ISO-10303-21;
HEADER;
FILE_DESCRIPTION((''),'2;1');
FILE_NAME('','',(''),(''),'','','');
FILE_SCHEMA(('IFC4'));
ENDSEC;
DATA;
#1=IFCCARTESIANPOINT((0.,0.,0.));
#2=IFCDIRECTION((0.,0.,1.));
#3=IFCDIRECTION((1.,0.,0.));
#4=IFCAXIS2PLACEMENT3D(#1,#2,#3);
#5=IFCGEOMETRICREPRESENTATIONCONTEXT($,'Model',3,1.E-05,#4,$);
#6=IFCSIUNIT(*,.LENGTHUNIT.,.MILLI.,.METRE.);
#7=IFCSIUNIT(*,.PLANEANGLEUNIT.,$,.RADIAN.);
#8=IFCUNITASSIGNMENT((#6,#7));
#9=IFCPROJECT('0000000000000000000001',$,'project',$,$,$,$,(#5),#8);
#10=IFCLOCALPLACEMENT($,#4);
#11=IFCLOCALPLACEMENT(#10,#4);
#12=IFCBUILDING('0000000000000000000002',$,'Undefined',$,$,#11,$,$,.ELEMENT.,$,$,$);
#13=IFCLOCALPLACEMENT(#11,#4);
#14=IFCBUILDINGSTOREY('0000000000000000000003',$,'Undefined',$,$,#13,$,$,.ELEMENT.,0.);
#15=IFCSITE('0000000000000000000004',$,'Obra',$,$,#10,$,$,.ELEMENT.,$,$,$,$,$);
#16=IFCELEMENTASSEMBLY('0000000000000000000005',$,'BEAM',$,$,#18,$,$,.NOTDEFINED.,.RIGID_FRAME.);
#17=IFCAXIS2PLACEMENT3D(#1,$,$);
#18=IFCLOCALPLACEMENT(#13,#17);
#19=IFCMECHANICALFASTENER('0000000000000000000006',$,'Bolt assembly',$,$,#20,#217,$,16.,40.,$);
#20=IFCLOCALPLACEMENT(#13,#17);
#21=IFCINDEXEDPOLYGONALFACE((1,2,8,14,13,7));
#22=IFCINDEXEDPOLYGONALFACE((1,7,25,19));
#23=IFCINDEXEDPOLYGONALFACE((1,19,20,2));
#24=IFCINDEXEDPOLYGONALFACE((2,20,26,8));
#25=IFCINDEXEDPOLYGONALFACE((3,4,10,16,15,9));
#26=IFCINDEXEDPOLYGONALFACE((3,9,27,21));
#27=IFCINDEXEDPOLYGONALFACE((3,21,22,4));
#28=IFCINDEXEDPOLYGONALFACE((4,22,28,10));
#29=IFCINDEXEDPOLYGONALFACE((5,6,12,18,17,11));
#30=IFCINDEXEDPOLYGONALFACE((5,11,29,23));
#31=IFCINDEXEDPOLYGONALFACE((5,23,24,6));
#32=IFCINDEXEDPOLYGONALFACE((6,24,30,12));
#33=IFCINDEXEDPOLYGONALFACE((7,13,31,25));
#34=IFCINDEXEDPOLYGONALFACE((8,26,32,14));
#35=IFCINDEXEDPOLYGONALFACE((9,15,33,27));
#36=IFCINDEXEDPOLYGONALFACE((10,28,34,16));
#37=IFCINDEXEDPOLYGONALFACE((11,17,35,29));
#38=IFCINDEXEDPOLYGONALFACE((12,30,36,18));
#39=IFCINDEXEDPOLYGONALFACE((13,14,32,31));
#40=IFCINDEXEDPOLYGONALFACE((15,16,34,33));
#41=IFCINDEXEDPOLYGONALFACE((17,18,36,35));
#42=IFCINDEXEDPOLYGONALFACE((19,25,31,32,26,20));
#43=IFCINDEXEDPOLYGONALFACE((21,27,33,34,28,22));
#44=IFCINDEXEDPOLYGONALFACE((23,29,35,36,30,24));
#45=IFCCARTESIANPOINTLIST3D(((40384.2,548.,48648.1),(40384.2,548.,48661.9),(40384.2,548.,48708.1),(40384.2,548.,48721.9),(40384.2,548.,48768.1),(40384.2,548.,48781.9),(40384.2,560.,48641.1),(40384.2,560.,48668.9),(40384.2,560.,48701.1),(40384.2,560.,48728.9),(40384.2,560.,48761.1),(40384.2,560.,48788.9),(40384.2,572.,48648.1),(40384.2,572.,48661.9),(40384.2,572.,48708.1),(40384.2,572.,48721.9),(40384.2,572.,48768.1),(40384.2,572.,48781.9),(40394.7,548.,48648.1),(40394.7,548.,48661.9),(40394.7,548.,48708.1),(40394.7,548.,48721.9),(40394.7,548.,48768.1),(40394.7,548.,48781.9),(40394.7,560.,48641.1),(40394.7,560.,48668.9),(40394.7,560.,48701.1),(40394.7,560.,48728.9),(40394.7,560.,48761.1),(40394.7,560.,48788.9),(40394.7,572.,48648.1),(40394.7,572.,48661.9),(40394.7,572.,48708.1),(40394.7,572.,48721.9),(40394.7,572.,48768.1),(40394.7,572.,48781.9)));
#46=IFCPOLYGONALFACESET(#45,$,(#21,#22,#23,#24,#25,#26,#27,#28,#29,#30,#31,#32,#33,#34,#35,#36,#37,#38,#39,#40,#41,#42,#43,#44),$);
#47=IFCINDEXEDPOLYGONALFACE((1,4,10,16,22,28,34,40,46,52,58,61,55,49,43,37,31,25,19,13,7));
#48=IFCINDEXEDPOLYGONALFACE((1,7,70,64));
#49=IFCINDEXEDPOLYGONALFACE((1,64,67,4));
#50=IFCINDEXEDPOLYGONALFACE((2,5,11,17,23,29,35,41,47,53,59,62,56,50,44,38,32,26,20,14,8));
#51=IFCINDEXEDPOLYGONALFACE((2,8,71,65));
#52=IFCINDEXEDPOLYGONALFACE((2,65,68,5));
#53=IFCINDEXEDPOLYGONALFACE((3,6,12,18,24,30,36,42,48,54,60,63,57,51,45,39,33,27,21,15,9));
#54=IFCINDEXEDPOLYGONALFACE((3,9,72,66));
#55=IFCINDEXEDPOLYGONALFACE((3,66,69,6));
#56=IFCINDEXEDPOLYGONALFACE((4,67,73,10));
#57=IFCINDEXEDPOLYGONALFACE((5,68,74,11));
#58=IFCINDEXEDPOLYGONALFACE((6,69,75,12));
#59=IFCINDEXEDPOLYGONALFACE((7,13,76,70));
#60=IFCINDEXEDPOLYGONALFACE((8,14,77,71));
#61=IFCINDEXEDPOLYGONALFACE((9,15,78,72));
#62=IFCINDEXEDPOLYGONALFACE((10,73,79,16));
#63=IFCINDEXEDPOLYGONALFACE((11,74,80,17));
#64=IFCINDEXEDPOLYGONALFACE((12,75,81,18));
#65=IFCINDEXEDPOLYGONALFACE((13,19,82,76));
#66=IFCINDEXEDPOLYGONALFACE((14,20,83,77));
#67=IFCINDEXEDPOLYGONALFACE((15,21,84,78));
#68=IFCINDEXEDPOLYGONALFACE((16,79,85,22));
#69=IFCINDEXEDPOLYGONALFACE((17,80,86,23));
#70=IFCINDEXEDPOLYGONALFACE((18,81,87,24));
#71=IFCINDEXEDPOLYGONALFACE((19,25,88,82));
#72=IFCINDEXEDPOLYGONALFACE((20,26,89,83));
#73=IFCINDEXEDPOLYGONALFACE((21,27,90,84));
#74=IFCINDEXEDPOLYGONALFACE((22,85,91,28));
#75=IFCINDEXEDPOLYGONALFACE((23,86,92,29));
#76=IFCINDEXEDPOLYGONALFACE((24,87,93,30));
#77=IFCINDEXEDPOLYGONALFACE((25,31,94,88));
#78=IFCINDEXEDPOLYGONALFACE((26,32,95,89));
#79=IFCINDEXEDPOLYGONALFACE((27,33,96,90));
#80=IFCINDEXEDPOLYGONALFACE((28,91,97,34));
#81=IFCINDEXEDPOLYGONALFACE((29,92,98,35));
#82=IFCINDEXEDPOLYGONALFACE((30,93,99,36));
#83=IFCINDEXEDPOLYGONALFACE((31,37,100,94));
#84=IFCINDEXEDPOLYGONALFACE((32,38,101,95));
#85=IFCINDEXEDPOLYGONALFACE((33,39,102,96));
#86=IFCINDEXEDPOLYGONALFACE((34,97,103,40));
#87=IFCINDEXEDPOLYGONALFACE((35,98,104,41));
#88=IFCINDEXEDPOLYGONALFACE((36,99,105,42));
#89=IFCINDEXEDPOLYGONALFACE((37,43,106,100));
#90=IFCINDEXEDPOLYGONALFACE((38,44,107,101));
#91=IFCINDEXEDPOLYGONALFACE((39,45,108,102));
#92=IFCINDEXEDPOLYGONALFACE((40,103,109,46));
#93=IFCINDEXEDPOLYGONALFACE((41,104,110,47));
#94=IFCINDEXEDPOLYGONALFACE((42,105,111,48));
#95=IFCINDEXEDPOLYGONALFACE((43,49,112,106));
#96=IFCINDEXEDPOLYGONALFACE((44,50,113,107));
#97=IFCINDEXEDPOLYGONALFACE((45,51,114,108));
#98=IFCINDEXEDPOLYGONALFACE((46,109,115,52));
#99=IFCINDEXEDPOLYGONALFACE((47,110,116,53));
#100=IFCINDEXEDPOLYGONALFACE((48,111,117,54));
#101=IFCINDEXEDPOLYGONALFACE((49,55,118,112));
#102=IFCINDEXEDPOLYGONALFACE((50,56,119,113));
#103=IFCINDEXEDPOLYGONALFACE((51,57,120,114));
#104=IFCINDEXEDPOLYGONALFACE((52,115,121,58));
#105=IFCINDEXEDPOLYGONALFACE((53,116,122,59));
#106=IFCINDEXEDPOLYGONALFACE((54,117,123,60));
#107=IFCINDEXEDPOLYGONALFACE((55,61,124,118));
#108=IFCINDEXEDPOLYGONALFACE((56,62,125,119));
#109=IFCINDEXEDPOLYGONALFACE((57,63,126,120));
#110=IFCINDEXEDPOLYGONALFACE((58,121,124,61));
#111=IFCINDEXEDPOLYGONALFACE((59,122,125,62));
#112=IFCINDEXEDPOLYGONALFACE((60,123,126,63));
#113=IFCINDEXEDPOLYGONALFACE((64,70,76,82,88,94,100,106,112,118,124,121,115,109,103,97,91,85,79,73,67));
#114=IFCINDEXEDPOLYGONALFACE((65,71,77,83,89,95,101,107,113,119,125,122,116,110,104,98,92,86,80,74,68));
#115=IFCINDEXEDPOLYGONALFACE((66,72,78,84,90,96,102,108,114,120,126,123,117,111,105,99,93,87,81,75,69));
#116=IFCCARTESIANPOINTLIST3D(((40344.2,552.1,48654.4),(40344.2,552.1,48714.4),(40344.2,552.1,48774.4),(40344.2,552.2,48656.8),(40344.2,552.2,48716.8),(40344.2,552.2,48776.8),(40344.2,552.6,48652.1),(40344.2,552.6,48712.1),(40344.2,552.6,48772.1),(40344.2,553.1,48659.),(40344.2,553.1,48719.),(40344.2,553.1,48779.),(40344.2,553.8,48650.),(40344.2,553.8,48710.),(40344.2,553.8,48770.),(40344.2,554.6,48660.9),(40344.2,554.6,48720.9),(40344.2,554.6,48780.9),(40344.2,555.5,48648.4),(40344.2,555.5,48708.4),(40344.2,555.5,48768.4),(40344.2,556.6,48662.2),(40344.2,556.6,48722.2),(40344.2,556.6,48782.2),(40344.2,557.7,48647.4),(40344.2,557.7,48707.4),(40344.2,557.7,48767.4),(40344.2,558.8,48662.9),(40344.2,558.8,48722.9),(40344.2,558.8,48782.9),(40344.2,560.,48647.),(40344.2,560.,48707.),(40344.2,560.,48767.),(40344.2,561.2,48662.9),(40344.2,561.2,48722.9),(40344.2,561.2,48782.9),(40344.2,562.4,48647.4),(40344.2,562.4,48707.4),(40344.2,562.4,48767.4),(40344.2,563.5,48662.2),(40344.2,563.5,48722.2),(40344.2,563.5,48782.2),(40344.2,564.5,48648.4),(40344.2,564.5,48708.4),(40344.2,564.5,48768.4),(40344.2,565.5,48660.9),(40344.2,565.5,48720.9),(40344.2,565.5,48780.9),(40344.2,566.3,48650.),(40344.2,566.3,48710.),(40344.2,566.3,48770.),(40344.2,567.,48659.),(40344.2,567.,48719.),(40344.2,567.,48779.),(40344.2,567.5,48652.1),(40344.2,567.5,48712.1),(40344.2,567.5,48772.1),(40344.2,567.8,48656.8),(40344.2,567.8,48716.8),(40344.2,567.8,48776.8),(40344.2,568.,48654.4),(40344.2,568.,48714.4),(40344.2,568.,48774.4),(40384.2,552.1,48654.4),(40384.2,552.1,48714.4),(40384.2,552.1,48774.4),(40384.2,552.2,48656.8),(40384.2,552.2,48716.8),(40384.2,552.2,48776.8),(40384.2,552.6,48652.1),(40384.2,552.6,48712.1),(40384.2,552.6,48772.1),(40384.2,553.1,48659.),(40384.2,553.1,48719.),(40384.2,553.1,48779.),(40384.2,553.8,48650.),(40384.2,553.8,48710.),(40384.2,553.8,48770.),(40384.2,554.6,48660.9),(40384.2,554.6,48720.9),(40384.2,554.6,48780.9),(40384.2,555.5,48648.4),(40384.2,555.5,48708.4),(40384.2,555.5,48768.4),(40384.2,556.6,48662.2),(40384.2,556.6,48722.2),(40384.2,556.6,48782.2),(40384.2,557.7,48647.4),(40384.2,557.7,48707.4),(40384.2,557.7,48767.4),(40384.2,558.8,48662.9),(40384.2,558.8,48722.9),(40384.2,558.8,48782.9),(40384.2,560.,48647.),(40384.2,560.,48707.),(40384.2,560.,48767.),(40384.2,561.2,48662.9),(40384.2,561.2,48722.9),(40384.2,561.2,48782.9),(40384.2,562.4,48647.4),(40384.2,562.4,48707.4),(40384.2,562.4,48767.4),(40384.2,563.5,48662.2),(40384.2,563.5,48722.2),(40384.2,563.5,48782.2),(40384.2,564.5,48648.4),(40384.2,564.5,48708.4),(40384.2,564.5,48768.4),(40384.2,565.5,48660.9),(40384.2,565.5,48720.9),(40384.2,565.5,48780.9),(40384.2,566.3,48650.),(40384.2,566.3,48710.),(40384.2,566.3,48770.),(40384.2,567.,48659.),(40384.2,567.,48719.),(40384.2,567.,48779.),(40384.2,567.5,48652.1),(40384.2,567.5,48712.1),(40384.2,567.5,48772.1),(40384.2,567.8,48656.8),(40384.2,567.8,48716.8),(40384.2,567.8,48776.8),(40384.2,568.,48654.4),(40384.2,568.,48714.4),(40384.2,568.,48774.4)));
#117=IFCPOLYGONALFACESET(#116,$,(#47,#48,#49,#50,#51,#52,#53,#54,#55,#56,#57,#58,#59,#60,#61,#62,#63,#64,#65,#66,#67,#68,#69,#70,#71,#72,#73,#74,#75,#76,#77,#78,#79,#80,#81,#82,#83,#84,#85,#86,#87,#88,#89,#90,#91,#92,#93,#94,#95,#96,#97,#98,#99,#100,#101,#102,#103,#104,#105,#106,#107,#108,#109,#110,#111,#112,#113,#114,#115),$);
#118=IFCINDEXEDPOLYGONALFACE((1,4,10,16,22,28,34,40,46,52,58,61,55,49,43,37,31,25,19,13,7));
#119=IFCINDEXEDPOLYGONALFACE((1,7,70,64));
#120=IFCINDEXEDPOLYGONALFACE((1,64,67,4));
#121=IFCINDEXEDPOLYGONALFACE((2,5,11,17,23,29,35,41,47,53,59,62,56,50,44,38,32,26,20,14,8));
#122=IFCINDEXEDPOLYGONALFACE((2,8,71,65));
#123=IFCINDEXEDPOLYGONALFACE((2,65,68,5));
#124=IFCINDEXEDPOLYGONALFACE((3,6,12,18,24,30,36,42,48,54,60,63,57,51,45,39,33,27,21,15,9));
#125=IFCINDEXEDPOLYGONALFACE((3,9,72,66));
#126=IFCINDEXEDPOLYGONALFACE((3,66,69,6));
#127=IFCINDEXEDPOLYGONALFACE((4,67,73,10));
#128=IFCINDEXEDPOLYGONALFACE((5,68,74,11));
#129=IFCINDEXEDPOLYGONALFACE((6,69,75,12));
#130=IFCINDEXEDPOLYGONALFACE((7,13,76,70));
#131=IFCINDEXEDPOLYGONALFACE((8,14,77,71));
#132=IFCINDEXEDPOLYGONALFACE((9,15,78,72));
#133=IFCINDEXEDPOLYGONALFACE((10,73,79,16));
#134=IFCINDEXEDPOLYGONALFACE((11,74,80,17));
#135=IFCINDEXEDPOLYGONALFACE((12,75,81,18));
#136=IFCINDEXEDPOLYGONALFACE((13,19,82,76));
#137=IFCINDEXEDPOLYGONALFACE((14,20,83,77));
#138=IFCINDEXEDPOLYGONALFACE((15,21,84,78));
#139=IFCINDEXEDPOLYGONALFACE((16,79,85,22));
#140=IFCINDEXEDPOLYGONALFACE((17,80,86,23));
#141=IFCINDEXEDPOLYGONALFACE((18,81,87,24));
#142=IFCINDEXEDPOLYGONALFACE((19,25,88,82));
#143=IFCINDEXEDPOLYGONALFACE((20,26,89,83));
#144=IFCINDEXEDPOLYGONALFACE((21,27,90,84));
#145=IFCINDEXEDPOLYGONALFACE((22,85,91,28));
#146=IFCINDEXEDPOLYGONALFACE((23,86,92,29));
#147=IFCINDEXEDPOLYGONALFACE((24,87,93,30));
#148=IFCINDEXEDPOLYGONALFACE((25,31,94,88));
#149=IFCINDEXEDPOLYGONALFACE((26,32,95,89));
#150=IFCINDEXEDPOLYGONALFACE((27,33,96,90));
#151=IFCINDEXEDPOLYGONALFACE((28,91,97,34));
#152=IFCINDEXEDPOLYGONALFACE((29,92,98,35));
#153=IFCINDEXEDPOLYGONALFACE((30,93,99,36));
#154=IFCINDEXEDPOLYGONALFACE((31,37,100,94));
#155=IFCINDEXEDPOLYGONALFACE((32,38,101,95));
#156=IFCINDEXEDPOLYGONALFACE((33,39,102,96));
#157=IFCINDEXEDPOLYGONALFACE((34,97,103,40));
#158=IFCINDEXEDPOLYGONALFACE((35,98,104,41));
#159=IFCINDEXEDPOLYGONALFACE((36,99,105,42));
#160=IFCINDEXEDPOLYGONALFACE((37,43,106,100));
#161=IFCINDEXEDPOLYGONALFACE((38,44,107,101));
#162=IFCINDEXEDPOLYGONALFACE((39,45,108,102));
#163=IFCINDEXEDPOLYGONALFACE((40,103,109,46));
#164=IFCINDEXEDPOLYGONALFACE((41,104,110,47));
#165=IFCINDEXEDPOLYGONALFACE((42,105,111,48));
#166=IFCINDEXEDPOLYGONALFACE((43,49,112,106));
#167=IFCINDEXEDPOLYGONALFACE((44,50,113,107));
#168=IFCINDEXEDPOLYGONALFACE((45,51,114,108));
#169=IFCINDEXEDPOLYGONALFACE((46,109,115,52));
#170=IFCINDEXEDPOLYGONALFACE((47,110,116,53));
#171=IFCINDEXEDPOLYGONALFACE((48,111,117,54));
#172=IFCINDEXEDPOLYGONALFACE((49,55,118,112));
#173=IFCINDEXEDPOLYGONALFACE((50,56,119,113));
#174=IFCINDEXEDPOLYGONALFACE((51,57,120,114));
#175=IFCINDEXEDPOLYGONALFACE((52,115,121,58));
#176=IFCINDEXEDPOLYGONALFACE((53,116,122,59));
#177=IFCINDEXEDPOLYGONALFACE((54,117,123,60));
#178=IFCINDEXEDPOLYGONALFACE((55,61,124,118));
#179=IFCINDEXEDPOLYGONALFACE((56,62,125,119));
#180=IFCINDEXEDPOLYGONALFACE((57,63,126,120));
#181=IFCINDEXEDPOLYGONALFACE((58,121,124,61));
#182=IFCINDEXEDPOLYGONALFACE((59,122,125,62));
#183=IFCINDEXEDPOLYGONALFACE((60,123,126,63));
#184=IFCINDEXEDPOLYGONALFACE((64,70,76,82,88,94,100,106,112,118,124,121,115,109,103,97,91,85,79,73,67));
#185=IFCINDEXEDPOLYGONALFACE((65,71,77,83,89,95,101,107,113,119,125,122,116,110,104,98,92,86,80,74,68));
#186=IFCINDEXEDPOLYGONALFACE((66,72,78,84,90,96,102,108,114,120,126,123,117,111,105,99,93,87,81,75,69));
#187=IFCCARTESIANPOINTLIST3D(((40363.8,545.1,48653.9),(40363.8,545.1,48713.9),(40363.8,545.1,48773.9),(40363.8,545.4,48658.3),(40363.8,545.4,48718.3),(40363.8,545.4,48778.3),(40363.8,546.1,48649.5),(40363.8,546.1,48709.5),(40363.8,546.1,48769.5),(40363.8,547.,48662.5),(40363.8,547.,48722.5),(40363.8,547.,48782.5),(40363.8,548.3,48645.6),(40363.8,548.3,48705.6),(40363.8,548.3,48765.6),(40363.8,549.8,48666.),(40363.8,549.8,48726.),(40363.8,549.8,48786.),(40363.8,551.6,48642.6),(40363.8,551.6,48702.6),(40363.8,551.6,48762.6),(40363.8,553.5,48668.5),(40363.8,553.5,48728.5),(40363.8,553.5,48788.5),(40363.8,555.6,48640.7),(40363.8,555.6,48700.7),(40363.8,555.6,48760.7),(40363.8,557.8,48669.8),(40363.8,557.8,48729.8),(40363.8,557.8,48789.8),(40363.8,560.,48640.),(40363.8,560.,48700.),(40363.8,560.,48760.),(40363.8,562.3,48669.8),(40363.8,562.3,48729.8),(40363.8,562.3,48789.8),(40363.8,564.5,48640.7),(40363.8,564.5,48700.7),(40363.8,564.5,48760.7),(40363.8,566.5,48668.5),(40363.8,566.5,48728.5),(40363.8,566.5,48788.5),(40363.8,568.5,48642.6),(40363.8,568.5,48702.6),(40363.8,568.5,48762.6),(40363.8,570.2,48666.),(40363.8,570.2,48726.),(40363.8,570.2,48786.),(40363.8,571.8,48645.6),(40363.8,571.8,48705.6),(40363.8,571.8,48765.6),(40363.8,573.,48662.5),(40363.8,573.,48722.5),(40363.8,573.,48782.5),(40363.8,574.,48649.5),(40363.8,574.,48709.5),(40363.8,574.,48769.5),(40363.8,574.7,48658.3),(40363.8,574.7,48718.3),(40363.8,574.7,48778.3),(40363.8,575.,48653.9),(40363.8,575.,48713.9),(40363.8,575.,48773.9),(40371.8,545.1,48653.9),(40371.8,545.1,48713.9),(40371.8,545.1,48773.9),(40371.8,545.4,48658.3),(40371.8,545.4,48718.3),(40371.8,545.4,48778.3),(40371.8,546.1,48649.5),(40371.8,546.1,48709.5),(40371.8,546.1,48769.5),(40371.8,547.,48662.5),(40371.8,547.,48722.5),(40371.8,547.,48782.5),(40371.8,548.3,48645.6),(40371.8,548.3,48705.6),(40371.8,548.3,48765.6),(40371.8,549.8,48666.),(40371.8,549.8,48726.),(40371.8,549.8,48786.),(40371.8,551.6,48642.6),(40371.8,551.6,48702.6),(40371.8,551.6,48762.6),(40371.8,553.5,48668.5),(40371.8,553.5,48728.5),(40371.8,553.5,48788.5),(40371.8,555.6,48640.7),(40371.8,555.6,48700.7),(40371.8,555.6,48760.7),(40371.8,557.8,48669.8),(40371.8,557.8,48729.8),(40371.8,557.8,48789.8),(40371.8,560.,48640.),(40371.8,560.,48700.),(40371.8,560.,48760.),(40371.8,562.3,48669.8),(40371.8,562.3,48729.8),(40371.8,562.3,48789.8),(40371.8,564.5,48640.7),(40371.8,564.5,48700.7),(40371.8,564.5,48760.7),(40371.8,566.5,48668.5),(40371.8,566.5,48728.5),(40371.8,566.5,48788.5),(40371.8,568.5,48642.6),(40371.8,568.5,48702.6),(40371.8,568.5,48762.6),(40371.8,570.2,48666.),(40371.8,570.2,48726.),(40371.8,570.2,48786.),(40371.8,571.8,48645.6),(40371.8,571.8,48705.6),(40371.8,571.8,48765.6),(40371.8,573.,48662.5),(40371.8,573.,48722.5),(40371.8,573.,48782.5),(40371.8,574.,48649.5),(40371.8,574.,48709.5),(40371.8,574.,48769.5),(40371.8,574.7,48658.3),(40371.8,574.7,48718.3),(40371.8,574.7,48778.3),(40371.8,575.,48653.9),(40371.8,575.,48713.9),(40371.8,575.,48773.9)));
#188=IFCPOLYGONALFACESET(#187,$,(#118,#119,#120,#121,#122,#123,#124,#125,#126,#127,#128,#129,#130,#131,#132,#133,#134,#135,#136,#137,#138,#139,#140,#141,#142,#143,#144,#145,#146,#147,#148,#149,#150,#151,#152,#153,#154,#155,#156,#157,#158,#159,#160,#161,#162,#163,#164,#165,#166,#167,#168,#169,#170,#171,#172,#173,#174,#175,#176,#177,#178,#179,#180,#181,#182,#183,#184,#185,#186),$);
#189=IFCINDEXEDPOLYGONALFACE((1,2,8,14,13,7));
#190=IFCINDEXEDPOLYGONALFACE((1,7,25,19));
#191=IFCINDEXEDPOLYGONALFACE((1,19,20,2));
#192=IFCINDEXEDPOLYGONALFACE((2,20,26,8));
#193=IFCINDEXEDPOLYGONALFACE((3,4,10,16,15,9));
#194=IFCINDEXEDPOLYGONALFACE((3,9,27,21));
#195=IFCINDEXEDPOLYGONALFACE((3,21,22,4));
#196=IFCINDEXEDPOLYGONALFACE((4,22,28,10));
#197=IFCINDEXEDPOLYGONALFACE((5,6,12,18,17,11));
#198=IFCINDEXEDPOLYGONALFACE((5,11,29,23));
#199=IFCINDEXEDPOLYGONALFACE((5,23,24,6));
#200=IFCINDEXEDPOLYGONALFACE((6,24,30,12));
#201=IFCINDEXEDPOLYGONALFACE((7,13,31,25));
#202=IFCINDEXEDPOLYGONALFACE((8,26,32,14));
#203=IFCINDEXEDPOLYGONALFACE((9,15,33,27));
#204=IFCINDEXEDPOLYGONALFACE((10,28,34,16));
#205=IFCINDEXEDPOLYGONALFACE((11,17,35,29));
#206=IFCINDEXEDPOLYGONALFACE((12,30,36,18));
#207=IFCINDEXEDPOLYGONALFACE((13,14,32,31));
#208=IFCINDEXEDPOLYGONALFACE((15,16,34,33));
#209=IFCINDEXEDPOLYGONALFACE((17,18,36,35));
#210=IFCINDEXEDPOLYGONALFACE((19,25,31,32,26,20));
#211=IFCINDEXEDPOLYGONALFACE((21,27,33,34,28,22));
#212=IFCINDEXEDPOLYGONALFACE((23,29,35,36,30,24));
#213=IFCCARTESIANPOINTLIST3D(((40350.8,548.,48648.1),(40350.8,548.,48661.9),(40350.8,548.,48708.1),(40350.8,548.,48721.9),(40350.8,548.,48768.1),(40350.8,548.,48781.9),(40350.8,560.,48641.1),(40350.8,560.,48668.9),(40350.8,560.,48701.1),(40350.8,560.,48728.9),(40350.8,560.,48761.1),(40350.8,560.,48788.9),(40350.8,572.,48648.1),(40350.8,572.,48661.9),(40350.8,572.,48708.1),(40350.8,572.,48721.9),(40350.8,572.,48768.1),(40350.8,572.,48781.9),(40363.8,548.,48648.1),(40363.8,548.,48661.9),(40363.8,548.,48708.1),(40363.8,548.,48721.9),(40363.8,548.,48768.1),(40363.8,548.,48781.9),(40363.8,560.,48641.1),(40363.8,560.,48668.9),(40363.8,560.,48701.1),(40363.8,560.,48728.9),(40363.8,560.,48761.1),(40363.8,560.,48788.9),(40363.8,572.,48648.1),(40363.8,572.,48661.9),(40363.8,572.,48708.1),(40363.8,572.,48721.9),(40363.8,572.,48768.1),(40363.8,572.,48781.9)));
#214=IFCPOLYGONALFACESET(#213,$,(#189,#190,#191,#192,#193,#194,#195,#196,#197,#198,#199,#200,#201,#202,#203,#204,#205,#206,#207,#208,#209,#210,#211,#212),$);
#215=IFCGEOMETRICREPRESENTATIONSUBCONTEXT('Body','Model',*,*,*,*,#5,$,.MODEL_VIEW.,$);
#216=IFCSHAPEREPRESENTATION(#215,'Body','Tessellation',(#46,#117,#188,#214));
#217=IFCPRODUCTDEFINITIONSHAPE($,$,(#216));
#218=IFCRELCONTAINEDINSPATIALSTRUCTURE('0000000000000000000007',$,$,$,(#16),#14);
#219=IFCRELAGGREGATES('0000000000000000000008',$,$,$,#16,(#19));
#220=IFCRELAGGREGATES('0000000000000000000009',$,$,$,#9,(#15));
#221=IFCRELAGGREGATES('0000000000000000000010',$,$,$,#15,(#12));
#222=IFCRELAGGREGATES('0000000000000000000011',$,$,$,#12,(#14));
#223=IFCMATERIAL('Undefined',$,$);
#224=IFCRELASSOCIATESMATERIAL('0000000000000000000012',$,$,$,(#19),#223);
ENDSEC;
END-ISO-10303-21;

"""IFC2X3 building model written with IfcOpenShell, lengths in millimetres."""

from ifc_helpers import new_model, si_unit, frame, origin_with_axes, origin_2d_with_axis, place, context, subcontext, project, spatial, polyline, circle, outline, extrude, source, transform, mapped, material, element, aggregate, save


model = new_model("IFC2X3")

# Units and contexts
model_context = context("Model", 3, precision=1e-05, world=origin_with_axes())
body_context = subcontext(model_context, "Body", "Model", "MODEL_VIEW")
ifc_project = project(units=[si_unit("LENGTHUNIT", "METRE", prefix="MILLI"), si_unit("PLANEANGLEUNIT", "RADIAN")], contexts=[model_context])

# Site, building, storey
site_placement = place(None, origin_with_axes())
site = spatial("IfcSite", under=ifc_project, at=site_placement, Name="Obra", CompositionType="ELEMENT")
building_placement = place(site_placement, origin_with_axes())
building = spatial("IfcBuilding", under=site, at=building_placement, Name="Undefined", CompositionType="ELEMENT")
storey_placement = place(building_placement, origin_with_axes())
storey = spatial("IfcBuildingStorey", under=building, at=storey_placement, Name="Undefined", CompositionType="ELEMENT", Elevation=0.0)

# Element assembly
assembly_1_placement = place(storey_placement, origin_with_axes())
assembly_1 = element("IfcElementAssembly", 1, at=assembly_1_placement, inside=storey, Name="BEAM", AssemblyPlace="NOTDEFINED", PredefinedType="RIGID_FRAME")

# Shared definitions
ifc_material_1 = material(Name="Undefined")

# Mechanical fastener
shared_shape_1 = source(origin_with_axes(), body_context, "Body", "SweptSolid", [
    extrude(outline(polyline([(13.9, 0.0), (6.9, 12.0), (-6.9, 12.0), (-13.9, 0.0), (-6.9, -12.0), (6.9, -12.0), (13.9, 0.0)])), frame((0.0, -19.7, 0.0), z_axis=(0.0, 1.0, 0.0), x_axis=(1.0, 0.0, 0.0)), (0.0, 0.0, 1.0), 10.6),
    extrude(circle(Radius=8.0, at=origin_2d_with_axis()), frame((0.0, -9.1, 0.0), z_axis=(0.0, 1.0, 0.0), x_axis=(1.0, 0.0, 0.0)), (0.0, 0.0, 1.0), 40.0),
    extrude(circle(Radius=15.0, at=origin_2d_with_axis()), frame((0.0, 3.3, 0.0), z_axis=(0.0, 1.0, 0.0), x_axis=(1.0, 0.0, 0.0)), (0.0, 0.0, 1.0), 8.0),
    extrude(outline(polyline([(13.9, 0.0), (6.9, 12.0), (-6.9, 12.0), (-13.9, 0.0), (-6.9, -12.0), (6.9, -12.0), (13.9, 0.0)])), frame((0.0, 11.3, 0.0), z_axis=(0.0, 1.0, 0.0), x_axis=(1.0, 0.0, 0.0)), (0.0, 0.0, 1.0), 13.0),
])
mechanical_fastener_1_placement = place(assembly_1_placement, frame((40375.1, 510.0, 48835.0), z_axis=(-0.000002, 1.0, 0.0), x_axis=(0.0, 0.0, -1.0)))
mechanical_fastener_1 = element("IfcMechanicalFastener", 2, at=mechanical_fastener_1_placement, material=ifc_material_1, Name="Bolt assembly", NominalDiameter=16.0, NominalLength=40.0, context=body_context, shape_type="MappedRepresentation", body=[
    mapped(shared_shape_1, transform((60.0, 0.0, 50.0))),
    mapped(shared_shape_1, transform((120.0, 0.0, 50.0))),
    mapped(shared_shape_1, transform((180.0, 0.0, 50.0))),
])
aggregate(assembly_1, [mechanical_fastener_1])

save(model, "model.ifc")
